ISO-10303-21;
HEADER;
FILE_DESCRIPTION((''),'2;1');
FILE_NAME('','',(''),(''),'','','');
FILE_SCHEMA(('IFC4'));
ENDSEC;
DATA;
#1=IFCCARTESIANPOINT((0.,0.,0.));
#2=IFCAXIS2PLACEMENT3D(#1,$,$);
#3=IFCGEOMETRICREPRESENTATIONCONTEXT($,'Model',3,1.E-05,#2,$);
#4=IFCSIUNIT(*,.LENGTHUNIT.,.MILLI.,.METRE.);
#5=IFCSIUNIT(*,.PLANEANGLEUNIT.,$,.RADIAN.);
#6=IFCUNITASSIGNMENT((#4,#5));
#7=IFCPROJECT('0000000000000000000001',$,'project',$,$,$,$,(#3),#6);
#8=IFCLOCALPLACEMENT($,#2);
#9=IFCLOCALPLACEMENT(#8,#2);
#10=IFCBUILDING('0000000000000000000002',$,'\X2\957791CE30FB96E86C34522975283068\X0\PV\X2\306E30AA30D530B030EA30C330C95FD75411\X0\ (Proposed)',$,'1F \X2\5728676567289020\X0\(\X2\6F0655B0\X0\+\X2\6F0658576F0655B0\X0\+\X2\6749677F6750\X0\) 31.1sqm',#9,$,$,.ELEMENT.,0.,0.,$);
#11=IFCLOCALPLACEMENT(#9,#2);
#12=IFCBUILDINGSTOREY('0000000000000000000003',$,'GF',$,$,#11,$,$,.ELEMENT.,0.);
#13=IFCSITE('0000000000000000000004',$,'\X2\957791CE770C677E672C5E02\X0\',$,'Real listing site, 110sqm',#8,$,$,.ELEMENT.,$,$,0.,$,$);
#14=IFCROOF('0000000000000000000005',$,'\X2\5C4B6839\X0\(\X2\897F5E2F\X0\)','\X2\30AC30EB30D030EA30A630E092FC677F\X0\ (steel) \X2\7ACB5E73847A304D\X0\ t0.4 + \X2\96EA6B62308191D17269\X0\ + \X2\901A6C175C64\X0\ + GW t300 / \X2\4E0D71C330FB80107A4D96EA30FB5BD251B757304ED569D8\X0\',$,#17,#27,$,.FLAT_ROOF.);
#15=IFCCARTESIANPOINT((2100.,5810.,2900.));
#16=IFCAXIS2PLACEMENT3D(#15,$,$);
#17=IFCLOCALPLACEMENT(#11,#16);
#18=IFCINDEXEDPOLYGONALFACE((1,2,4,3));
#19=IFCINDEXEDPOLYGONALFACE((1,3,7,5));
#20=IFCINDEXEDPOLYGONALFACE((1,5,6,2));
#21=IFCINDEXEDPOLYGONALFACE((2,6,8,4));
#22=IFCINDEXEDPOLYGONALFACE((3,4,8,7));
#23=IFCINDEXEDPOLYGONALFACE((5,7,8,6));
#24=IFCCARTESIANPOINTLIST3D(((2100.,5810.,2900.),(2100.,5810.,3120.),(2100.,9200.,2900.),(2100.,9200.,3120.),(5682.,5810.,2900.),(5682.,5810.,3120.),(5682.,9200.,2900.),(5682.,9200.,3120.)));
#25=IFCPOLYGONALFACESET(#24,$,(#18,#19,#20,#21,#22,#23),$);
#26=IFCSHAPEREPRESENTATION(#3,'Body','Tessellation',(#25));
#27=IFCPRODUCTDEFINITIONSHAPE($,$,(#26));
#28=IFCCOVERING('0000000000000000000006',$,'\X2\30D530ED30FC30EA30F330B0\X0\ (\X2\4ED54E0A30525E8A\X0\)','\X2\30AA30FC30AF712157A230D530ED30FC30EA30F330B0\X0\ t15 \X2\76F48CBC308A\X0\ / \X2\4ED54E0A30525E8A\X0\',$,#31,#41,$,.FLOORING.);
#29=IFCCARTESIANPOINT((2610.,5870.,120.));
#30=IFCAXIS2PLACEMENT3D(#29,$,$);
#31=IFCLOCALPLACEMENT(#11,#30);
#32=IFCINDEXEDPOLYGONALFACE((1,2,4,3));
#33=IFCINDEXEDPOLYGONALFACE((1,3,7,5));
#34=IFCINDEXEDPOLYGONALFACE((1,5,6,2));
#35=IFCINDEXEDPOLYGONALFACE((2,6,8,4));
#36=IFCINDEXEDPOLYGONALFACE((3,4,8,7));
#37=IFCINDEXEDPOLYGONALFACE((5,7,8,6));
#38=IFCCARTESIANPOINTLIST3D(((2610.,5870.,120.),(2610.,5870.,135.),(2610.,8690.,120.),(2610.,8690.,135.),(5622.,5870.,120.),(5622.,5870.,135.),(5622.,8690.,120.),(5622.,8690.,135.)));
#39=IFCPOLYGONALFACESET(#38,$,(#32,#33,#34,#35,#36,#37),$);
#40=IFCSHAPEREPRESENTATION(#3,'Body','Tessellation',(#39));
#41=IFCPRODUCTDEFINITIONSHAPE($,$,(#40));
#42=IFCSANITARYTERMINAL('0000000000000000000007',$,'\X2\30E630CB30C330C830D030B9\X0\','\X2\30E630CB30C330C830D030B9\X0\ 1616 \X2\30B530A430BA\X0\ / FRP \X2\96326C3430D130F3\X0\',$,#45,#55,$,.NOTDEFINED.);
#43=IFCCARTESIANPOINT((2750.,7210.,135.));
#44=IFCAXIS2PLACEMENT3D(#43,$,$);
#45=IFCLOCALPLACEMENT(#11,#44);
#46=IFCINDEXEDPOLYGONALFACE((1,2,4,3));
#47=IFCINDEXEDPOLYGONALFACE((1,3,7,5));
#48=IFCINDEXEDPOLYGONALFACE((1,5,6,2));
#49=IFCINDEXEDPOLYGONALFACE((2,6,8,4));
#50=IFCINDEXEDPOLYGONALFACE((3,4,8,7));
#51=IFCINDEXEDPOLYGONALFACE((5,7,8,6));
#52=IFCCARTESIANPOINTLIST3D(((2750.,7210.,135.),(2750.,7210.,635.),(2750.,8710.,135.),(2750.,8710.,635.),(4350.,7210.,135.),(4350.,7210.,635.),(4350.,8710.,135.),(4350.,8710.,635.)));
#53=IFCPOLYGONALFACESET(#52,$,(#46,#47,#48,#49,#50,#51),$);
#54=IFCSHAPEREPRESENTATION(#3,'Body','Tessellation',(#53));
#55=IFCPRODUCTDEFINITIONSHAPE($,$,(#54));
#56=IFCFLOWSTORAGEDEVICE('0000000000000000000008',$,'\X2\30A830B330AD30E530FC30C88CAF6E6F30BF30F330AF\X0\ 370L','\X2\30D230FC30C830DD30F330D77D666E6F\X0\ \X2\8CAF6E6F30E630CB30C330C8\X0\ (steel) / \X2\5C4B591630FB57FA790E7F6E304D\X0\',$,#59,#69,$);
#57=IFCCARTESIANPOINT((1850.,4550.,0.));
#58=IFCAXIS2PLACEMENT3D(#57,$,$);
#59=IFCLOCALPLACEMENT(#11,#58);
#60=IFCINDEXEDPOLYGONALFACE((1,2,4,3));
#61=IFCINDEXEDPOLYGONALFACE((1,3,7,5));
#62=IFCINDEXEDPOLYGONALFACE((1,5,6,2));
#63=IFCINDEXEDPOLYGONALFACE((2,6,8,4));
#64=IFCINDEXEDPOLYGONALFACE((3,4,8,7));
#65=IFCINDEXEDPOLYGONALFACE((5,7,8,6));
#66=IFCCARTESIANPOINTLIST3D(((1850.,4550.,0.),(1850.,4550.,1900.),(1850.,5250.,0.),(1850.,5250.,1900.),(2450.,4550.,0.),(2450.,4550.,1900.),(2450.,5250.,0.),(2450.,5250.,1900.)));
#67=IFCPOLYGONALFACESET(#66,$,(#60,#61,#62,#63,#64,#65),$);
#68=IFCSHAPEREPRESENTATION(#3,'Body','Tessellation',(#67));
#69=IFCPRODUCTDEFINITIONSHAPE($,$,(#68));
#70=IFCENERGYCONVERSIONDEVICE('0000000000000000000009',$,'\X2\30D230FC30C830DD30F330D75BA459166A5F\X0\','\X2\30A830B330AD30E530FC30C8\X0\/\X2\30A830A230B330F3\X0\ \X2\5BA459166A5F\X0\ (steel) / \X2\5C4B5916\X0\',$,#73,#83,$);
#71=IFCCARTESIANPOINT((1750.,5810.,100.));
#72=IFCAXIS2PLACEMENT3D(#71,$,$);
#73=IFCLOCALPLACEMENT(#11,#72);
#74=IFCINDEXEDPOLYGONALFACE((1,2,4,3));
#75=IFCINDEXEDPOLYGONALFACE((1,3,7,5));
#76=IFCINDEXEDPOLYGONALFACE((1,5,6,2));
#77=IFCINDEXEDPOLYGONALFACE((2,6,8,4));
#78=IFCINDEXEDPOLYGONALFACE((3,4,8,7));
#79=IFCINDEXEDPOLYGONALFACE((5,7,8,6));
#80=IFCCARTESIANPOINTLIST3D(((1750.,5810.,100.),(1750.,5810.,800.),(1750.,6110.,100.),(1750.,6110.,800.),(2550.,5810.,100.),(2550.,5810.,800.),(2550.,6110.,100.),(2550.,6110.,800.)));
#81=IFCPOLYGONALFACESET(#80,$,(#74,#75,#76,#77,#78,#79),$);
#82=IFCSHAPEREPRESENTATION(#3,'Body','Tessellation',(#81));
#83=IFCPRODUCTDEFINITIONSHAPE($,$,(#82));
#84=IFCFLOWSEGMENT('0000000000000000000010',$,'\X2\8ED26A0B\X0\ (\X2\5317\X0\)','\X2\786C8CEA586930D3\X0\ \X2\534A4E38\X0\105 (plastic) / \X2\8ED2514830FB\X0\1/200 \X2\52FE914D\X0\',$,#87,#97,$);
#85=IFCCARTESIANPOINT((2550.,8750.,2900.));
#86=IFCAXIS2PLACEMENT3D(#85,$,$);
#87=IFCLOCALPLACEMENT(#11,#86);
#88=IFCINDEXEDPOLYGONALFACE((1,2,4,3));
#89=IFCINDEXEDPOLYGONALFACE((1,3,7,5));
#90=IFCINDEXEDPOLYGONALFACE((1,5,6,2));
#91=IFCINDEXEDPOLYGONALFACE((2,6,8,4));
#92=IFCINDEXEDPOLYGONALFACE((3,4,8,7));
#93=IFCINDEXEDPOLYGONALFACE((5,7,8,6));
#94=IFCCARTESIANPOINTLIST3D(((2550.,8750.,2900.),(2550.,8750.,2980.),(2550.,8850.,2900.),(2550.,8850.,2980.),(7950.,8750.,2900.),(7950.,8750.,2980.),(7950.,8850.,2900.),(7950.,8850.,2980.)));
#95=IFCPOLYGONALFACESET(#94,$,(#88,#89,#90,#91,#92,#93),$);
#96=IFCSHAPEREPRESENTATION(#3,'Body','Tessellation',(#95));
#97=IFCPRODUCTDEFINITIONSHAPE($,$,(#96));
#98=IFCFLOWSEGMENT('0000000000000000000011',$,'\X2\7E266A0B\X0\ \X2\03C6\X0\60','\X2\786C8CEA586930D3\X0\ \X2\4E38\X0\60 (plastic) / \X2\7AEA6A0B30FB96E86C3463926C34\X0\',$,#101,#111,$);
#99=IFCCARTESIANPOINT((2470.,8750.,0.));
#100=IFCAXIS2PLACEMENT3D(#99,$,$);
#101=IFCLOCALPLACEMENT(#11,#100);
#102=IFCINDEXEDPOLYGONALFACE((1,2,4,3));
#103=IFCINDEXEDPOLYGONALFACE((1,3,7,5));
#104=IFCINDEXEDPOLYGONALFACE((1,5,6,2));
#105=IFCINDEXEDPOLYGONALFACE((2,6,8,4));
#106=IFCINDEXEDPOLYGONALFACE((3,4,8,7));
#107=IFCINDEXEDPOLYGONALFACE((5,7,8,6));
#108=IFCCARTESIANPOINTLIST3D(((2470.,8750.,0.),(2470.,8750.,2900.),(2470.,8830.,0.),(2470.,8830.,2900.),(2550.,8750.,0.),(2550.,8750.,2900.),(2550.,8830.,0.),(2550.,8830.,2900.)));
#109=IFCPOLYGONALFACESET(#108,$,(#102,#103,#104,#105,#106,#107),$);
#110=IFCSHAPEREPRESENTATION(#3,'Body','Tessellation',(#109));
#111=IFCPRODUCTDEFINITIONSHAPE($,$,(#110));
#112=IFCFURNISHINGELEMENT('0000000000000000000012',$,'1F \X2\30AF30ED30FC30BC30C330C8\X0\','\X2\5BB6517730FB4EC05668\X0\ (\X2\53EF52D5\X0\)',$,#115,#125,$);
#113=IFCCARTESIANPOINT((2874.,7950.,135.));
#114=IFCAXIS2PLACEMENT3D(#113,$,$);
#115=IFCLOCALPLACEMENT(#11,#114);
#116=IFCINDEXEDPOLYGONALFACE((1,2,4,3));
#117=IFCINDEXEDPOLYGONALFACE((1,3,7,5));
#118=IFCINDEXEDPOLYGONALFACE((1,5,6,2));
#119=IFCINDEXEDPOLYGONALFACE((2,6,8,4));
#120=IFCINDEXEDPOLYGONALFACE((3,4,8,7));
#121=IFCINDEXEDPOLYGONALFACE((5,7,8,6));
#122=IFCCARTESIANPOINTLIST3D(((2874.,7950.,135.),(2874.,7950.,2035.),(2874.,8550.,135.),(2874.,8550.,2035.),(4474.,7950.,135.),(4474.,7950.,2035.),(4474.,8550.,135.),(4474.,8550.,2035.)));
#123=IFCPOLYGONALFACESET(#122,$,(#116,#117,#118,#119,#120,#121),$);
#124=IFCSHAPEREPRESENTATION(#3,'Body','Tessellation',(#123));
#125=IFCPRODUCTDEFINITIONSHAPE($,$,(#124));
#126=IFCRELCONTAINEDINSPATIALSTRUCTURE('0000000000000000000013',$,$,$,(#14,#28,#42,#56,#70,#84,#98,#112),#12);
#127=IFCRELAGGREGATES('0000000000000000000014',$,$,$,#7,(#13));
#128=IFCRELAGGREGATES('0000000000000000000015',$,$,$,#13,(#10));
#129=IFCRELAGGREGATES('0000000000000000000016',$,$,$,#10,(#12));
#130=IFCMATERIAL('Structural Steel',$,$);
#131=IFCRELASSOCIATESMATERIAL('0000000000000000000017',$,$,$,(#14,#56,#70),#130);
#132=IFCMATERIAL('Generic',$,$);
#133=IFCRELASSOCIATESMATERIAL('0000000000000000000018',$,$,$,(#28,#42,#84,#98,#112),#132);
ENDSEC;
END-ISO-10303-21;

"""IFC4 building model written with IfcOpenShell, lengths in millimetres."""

from ifc_helpers import new_model, si_unit, frame, frame_2d, origin, place, context, project, spatial, rectangle, extrude, material, element, save


model = new_model("IFC4")

# Units and contexts
model_context = context("Model", 3, precision=1e-05, world=origin())
ifc_project = project(units=[si_unit("LENGTHUNIT", "METRE", prefix="MILLI"), si_unit("PLANEANGLEUNIT", "RADIAN")], contexts=[model_context])

# Site, building, storey
site_placement = place(None, origin())
site = spatial("IfcSite", under=ifc_project, at=site_placement, Name="長野県松本市", ObjectType="Real listing site, 110sqm", CompositionType="ELEMENT", RefElevation=0.0)
building_placement = place(site_placement, origin())
building = spatial("IfcBuilding", under=site, at=building_placement, Name="長野・雨水利用とPVのオフグリッド志向 (Proposed)", ObjectType="1F 在来木造(漆喰+漆塗漆喰+杉板材) 31.1sqm", CompositionType="ELEMENT", ElevationOfRefHeight=0.0, ElevationOfTerrain=0.0)
storey_placement = place(building_placement, origin())
storey = spatial("IfcBuildingStorey", under=building, at=storey_placement, Name="GF", CompositionType="ELEMENT", Elevation=0.0)

# Roof
ifc_material_1 = material(Name="Structural Steel")
roof_placement = place(storey_placement, frame((2100.0, 5810.0, 2900.0)))
element("IfcRoof", 1, at=roof_placement, inside=storey, material=ifc_material_1, Name="屋根(西帯)", Description="ガルバリウム鋼板 (steel) 立平葺き t0.4 + 雪止め金物 + 通気層 + GW t300 / 不燃・耐積雪・寒冷地仕様", PredefinedType="FLAT_ROOF", context=model_context, shape_type="SweptSolid", body=[
    extrude(rectangle(XDim=3582.0, YDim=3390.0, at=frame_2d((1791.0, 1695.0))), frame((2100.0, 5810.0, 2900.0)), (0.0, 0.0, 1.0), 220.0),
])

# Covering
ifc_material_2 = material(Name="Generic")
covering_placement = place(storey_placement, frame((2610.0, 5870.0, 120.0)))
element("IfcCovering", 2, at=covering_placement, inside=storey, material=ifc_material_2, Name="フローリング (仕上げ床)", Description="オーク無垢フローリング t15 直貼り / 仕上げ床", PredefinedType="FLOORING", context=model_context, shape_type="SweptSolid", body=[
    extrude(rectangle(XDim=3012.0, YDim=2820.0, at=frame_2d((1506.0, 1410.0))), frame((2610.0, 5870.0, 120.0)), (0.0, 0.0, 1.0), 15.0),
])

# Sanitary terminal
sanitary_terminal_placement = place(storey_placement, frame((2750.0, 7210.0, 135.0)))
element("IfcSanitaryTerminal", 3, at=sanitary_terminal_placement, inside=storey, material=ifc_material_2, Name="ユニットバス", Description="ユニットバス 1616 サイズ / FRP 防水パン", PredefinedType="NOTDEFINED", context=model_context, shape_type="SweptSolid", body=[
    extrude(rectangle(XDim=1600.0, YDim=1500.0, at=frame_2d((800.0, 750.0))), frame((2750.0, 7210.0, 135.0)), (0.0, 0.0, 1.0), 500.0),
])

# Flow storage device
flow_storage_device_placement = place(storey_placement, frame((1850.0, 4550.0, 0.0)))
element("IfcFlowStorageDevice", 4, at=flow_storage_device_placement, inside=storey, material=ifc_material_1, Name="エコキュート貯湯タンク 370L", Description="ヒートポンプ給湯 貯湯ユニット (steel) / 屋外・基礎置き", context=model_context, shape_type="SweptSolid", body=[
    extrude(rectangle(XDim=600.0, YDim=700.0, at=frame_2d((300.0, 350.0))), frame((1850.0, 4550.0, 0.0)), (0.0, 0.0, 1.0), 1900.0),
])

# Energy conversion device
energy_conversion_device_placement = place(storey_placement, frame((1750.0, 5810.0, 100.0)))
element("IfcEnergyConversionDevice", 5, at=energy_conversion_device_placement, inside=storey, material=ifc_material_1, Name="ヒートポンプ室外機", Description="エコキュート/エアコン 室外機 (steel) / 屋外", context=model_context, shape_type="SweptSolid", body=[
    extrude(rectangle(XDim=800.0, YDim=300.0, at=frame_2d((400.0, 150.0))), frame((1750.0, 5810.0, 100.0)), (0.0, 0.0, 1.0), 700.0),
])

# Flow segments
flow_segment_1_placement = place(storey_placement, frame((2550.0, 8750.0, 2900.0)))
element("IfcFlowSegment", 6, at=flow_segment_1_placement, inside=storey, material=ifc_material_2, Name="軒樋 (北)", Description="硬質塩ビ 半丸105 (plastic) / 軒先・1/200 勾配", context=model_context, shape_type="SweptSolid", body=[
    extrude(rectangle(XDim=5400.0, YDim=100.0, at=frame_2d((2700.0, 50.0))), frame((2550.0, 8750.0, 2900.0)), (0.0, 0.0, 1.0), 80.0),
])
flow_segment_2_placement = place(storey_placement, frame((2470.0, 8750.0, 0.0)))
element("IfcFlowSegment", 7, at=flow_segment_2_placement, inside=storey, material=ifc_material_2, Name="縦樋 φ60", Description="硬質塩ビ 丸60 (plastic) / 竪樋・雨水排水", context=model_context, shape_type="SweptSolid", body=[
    extrude(rectangle(XDim=80.0, YDim=80.0, at=frame_2d((40.0, 40.0))), frame((2470.0, 8750.0, 0.0)), (0.0, 0.0, 1.0), 2900.0),
])

# Furnishing element
furnishing_placement = place(storey_placement, frame((2874.0, 7950.0, 135.0)))
element("IfcFurnishingElement", 8, at=furnishing_placement, inside=storey, material=ifc_material_2, Name="1F クローゼット", Description="家具・什器 (可動)", context=model_context, shape_type="SweptSolid", body=[
    extrude(rectangle(XDim=1600.0, YDim=600.0, at=frame_2d((800.0, 300.0))), frame((2874.0, 7950.0, 135.0)), (0.0, 0.0, 1.0), 1900.0),
])

save(model, "model.ifc")
